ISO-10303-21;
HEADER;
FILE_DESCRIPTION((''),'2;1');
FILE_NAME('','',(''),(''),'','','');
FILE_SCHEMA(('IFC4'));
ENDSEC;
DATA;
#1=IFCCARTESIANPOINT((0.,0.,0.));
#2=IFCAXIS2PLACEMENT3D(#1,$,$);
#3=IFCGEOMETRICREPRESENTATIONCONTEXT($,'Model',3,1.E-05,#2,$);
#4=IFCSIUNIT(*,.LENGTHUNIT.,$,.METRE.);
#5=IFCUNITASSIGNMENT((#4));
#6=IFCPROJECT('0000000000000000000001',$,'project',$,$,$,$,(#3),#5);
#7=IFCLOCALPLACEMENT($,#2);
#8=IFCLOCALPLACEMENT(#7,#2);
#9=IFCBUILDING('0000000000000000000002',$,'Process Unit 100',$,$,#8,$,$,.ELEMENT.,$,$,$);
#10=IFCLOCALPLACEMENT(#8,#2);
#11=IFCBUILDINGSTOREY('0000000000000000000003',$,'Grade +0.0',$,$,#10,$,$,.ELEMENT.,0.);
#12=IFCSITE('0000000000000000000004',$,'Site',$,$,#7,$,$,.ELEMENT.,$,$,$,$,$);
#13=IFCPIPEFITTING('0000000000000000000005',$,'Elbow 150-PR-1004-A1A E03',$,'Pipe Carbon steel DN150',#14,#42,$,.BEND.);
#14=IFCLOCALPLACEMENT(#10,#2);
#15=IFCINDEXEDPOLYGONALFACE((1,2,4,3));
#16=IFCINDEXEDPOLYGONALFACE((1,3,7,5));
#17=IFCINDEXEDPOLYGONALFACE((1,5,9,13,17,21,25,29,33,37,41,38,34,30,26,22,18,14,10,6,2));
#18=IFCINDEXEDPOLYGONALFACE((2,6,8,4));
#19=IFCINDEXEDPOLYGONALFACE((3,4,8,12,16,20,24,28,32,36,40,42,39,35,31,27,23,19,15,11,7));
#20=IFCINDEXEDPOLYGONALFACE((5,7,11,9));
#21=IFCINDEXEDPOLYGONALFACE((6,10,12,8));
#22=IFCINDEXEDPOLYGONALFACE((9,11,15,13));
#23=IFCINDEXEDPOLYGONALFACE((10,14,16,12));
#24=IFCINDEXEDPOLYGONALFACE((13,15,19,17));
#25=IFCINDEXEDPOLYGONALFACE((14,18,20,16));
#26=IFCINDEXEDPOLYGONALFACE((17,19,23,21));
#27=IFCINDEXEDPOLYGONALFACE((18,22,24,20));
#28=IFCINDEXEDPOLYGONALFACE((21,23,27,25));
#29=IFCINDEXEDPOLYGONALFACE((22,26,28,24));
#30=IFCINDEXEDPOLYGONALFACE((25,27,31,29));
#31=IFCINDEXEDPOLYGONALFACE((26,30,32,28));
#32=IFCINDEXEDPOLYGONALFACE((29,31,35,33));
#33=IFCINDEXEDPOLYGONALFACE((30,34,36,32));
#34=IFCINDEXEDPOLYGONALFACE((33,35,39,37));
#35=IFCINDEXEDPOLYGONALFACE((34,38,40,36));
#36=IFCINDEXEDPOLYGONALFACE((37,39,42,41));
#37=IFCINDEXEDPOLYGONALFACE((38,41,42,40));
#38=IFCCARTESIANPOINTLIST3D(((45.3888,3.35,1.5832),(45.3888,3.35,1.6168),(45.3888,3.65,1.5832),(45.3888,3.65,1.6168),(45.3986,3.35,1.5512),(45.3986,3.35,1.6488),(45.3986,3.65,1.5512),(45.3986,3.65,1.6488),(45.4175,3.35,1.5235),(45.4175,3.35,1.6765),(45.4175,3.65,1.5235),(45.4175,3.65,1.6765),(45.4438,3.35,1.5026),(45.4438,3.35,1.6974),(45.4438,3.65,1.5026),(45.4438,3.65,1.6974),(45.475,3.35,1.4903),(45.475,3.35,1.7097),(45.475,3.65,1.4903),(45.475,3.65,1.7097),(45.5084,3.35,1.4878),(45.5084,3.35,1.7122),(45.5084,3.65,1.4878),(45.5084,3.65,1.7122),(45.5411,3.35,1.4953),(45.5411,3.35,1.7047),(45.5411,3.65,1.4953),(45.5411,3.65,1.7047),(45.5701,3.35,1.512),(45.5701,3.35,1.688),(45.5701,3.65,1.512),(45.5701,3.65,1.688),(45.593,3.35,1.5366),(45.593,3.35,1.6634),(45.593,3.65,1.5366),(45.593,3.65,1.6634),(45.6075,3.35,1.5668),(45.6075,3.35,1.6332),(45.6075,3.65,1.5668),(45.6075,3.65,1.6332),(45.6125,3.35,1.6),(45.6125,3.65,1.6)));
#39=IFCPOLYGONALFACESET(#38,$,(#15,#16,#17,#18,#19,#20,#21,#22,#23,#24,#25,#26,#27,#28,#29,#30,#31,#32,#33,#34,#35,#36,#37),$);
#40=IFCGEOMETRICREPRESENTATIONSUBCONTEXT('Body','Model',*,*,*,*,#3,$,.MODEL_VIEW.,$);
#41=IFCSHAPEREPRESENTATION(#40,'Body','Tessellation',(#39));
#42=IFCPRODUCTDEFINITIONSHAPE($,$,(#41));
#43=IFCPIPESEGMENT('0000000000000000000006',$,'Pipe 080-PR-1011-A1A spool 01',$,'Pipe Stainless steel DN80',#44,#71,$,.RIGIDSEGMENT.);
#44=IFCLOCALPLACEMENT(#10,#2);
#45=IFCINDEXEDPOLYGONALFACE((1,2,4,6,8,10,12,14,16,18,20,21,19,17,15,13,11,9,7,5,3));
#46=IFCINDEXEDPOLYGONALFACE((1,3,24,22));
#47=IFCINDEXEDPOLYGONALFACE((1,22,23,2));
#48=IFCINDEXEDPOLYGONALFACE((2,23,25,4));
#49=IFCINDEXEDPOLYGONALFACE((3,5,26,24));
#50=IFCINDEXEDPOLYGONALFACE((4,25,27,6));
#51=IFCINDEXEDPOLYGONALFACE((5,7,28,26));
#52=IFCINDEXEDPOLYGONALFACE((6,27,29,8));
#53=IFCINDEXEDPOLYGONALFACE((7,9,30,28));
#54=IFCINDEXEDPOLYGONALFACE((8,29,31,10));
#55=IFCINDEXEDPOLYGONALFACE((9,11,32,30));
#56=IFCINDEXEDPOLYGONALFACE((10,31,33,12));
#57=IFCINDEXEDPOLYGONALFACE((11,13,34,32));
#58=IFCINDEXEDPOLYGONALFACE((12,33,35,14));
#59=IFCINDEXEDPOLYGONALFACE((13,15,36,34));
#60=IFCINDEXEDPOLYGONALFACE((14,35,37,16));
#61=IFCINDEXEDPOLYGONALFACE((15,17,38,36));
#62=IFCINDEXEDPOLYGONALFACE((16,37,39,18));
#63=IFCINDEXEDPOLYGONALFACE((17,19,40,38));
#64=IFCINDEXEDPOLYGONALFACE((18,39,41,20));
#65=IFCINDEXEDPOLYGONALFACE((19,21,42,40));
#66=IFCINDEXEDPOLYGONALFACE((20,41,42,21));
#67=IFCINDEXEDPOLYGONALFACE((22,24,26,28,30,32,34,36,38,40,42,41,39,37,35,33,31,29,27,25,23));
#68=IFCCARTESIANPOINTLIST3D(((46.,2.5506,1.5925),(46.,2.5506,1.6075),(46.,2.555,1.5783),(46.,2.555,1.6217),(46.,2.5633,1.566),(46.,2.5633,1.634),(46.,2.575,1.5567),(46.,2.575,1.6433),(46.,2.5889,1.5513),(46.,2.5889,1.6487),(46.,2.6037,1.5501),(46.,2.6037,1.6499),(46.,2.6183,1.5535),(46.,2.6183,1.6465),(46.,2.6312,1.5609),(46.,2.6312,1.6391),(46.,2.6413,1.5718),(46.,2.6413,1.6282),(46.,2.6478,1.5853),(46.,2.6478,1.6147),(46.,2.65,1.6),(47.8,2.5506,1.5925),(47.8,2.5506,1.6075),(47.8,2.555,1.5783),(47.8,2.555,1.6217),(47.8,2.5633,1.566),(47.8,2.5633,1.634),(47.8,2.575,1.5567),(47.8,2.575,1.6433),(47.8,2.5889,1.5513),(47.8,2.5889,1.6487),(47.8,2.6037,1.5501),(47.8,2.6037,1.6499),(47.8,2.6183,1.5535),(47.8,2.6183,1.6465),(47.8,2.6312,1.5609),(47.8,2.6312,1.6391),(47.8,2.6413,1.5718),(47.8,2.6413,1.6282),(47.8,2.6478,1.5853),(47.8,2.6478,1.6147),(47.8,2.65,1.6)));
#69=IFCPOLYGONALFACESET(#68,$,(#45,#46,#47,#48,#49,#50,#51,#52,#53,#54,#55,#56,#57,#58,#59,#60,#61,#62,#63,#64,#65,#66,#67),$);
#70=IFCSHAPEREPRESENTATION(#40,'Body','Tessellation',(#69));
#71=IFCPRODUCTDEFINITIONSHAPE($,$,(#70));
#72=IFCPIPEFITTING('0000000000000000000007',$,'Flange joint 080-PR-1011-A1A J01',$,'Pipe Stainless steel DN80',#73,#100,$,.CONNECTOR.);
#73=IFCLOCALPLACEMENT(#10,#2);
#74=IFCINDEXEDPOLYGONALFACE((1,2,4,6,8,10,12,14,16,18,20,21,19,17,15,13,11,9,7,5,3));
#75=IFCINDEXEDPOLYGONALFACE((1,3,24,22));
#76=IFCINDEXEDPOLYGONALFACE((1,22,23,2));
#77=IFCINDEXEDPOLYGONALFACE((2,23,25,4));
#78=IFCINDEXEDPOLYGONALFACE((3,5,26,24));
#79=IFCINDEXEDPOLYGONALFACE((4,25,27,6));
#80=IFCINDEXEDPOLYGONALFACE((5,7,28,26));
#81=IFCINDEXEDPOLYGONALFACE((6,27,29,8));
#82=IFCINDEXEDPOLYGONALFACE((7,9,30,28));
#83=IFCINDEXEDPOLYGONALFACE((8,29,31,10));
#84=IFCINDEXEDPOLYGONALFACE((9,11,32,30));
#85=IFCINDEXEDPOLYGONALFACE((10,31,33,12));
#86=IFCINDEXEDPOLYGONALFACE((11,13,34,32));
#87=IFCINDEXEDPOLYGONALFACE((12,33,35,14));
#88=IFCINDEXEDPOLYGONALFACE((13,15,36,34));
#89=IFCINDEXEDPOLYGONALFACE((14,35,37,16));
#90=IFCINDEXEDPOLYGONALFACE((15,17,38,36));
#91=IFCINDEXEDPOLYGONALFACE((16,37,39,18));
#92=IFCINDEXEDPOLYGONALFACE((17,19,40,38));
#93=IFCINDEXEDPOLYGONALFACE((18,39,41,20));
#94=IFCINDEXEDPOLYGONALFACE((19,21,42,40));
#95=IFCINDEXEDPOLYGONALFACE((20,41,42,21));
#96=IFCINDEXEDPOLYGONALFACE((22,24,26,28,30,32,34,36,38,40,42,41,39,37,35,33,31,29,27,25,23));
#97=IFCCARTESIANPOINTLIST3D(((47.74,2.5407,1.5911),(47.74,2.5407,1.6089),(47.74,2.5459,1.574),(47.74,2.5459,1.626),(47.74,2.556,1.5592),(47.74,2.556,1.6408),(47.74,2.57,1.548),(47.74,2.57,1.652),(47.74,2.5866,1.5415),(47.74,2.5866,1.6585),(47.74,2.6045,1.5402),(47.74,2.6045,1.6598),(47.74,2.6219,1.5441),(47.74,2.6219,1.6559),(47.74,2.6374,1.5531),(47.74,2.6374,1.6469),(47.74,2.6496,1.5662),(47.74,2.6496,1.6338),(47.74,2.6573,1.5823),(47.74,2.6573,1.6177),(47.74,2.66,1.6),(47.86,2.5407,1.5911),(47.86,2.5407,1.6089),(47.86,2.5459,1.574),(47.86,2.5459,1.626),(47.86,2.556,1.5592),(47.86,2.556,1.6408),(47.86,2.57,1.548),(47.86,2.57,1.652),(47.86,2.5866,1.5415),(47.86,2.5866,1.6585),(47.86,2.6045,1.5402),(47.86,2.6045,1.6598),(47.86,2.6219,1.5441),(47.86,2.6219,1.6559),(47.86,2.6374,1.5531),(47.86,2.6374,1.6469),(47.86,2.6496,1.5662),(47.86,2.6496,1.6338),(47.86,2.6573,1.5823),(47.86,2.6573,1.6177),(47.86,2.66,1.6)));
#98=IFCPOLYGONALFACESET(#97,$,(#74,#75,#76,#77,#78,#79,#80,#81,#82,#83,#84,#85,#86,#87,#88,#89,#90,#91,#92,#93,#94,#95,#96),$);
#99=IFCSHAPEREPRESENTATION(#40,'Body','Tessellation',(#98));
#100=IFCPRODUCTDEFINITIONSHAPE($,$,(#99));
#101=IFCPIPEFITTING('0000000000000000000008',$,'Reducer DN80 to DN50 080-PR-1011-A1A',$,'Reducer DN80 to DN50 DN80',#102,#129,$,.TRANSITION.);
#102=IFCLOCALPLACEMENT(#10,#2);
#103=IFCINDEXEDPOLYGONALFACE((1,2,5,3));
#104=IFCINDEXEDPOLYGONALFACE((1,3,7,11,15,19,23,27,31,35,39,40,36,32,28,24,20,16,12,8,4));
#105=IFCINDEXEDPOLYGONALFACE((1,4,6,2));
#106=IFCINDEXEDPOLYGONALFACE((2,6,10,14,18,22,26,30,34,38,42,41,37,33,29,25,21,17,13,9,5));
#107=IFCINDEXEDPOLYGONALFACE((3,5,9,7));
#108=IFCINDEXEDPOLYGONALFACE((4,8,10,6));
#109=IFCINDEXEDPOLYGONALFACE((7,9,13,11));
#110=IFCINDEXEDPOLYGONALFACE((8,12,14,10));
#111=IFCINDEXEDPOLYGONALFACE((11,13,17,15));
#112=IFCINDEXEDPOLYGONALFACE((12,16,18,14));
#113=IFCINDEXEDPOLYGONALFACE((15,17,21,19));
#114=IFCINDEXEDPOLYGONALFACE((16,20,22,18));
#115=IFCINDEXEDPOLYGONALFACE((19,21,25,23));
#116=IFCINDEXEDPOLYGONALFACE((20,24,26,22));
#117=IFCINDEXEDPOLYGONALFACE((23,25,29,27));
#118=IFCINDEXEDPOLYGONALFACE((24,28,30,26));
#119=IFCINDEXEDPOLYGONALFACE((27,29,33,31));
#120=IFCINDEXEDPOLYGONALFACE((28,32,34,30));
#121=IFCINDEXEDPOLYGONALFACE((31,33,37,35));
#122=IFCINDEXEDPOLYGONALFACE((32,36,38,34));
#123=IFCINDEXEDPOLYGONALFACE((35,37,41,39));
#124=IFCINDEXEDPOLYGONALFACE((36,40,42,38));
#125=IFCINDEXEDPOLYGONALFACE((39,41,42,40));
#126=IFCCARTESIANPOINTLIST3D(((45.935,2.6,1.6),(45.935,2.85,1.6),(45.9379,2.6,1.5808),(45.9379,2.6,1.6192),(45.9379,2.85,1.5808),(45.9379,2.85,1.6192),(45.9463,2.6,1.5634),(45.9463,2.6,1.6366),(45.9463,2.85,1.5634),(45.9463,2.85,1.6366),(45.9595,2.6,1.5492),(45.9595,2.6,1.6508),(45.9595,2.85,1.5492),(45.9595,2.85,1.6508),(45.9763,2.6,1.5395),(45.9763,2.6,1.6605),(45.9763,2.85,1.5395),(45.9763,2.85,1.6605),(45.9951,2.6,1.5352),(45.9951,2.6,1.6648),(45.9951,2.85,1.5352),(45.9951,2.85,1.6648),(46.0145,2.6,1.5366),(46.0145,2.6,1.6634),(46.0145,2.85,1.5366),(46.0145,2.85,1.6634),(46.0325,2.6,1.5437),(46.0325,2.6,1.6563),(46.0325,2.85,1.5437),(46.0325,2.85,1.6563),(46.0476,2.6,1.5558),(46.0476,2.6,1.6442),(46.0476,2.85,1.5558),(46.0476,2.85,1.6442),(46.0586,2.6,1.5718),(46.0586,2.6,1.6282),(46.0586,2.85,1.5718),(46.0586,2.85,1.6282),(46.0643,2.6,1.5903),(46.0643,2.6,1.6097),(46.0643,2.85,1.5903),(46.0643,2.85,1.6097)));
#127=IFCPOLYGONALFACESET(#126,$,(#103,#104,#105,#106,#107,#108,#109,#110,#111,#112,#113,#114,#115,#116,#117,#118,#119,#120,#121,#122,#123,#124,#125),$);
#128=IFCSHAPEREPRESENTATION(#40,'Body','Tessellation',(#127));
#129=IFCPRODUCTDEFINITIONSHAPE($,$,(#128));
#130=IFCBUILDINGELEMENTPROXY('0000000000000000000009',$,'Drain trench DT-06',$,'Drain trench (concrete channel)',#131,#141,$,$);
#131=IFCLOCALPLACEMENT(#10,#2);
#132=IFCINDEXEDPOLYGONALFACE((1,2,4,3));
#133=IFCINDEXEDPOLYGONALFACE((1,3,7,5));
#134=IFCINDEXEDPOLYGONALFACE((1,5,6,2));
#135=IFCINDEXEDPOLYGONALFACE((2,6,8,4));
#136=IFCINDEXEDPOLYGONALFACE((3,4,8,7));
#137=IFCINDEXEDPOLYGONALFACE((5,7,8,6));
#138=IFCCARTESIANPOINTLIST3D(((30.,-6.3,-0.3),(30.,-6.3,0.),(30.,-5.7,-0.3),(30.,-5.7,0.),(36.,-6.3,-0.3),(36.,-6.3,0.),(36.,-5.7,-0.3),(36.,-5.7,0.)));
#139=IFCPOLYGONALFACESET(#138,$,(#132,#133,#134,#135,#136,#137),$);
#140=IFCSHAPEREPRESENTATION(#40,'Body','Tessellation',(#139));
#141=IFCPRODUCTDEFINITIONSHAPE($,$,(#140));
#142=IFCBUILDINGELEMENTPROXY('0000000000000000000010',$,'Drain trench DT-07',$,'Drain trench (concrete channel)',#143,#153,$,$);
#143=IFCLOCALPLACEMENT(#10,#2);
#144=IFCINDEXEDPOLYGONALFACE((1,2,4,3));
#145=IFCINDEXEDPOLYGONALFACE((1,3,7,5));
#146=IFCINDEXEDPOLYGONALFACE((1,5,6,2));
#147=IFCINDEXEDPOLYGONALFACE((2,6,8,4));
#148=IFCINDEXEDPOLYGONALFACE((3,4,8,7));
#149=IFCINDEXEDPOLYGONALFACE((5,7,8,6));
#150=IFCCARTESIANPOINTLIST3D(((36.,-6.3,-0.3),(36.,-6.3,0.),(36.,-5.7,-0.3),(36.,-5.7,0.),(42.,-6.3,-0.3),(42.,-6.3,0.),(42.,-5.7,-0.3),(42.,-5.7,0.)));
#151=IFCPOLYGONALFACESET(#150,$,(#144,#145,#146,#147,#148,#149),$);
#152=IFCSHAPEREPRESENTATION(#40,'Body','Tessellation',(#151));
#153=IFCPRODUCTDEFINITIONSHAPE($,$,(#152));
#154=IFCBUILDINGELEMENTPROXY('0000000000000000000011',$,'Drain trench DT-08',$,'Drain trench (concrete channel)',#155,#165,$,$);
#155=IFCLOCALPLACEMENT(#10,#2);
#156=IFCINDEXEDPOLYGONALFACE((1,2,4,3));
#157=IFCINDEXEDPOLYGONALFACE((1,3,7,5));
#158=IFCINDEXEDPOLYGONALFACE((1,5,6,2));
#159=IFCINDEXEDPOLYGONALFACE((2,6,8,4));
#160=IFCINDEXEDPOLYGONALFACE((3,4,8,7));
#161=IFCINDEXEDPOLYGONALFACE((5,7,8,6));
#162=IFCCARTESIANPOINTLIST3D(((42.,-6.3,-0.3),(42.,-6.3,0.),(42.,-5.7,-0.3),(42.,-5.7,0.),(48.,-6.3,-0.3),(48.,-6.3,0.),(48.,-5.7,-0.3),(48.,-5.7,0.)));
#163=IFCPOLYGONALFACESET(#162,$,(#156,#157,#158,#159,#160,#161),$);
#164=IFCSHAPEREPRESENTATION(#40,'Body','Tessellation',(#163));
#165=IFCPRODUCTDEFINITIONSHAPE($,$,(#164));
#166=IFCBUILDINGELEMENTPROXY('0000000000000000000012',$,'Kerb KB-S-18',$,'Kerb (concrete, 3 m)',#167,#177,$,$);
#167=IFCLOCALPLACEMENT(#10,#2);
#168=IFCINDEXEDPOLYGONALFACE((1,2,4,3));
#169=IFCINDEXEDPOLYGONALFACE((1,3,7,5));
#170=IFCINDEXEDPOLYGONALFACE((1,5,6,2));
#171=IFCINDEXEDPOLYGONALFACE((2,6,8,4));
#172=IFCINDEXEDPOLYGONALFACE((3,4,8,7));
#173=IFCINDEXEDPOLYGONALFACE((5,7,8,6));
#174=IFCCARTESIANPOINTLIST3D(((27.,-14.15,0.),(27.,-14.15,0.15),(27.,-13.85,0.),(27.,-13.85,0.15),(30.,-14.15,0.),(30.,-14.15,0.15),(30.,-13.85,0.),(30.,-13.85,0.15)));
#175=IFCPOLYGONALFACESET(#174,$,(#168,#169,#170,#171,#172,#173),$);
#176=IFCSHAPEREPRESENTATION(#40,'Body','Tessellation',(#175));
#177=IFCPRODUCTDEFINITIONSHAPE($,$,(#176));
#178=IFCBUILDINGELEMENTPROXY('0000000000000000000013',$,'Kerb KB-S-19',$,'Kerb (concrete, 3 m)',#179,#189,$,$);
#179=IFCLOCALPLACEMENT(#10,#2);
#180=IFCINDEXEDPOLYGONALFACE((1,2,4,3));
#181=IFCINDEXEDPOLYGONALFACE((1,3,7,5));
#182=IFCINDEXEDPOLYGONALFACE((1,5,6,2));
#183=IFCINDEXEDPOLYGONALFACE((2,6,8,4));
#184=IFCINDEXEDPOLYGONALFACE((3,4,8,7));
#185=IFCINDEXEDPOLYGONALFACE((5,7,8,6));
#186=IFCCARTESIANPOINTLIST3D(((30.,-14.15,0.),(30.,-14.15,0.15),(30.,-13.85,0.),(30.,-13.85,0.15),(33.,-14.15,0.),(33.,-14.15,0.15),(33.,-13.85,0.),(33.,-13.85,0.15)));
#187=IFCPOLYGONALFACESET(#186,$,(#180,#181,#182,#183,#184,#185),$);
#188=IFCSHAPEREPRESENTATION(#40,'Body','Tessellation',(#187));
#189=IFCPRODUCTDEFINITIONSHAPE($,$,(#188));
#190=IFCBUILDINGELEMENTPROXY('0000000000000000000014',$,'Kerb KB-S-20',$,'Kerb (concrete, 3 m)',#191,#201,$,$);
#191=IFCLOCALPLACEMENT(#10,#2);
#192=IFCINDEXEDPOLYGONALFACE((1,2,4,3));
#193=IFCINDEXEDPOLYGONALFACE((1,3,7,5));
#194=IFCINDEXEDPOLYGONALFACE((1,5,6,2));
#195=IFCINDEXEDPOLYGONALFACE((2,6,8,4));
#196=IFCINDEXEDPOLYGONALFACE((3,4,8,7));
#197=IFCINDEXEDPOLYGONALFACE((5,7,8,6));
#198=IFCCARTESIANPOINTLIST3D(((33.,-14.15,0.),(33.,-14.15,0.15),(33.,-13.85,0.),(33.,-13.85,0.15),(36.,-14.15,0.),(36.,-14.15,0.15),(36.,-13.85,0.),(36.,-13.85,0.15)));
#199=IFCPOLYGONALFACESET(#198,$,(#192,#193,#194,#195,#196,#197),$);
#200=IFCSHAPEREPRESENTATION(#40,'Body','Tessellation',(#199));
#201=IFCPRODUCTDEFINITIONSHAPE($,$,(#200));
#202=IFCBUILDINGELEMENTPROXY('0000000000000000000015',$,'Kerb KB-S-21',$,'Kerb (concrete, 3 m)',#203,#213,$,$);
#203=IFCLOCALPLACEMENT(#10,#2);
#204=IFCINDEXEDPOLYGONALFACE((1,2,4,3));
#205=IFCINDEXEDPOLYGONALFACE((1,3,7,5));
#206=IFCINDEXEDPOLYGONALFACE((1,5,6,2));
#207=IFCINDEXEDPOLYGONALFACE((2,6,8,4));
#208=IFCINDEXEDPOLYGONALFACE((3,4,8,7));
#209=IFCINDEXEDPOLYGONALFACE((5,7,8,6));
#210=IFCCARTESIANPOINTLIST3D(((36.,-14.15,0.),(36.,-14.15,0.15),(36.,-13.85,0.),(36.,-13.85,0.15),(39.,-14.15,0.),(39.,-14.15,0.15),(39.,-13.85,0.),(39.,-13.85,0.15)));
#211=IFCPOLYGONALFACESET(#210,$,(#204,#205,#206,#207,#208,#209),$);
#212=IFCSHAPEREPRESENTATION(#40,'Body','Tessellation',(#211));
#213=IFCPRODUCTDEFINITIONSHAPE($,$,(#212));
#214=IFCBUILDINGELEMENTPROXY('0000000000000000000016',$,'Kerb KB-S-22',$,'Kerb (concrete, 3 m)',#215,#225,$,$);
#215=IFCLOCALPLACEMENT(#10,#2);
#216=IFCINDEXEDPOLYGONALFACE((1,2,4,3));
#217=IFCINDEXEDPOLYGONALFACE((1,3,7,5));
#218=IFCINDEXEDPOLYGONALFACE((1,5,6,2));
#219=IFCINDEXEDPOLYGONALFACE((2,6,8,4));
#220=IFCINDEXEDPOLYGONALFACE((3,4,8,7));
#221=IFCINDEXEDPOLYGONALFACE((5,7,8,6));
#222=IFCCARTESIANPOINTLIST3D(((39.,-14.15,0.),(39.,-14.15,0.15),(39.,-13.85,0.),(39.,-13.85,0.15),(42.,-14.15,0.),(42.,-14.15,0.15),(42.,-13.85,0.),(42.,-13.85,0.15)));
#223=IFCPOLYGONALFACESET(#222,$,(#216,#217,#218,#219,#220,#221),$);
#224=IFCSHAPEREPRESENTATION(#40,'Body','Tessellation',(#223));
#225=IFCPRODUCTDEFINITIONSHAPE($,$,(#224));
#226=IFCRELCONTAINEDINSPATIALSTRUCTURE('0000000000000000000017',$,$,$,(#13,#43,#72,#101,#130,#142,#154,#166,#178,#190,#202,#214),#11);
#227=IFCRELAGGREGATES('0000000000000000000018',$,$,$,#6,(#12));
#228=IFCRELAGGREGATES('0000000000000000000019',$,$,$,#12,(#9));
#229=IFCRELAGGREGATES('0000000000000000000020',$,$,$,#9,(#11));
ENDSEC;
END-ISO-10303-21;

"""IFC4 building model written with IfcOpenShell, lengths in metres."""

from ifc_helpers import new_model, si_unit, frame, origin, place, context, subcontext, project, spatial, rectangle, circle, extrude, element, save


model = new_model("IFC4")

# Units and contexts
model_context = context("Model", 3, precision=1e-05, world=origin())
body_context = subcontext(model_context, "Body", "Model", "MODEL_VIEW")
ifc_project = project(units=[si_unit("LENGTHUNIT", "METRE")], contexts=[model_context])

# Site, building, storey
site_placement = place(None, origin())
site = spatial("IfcSite", under=ifc_project, at=site_placement, Name="Site", CompositionType="ELEMENT")
building_placement = place(site_placement, origin())
building = spatial("IfcBuilding", under=site, at=building_placement, Name="Process Unit 100", CompositionType="ELEMENT")
storey_placement = place(building_placement, origin())
storey = spatial("IfcBuildingStorey", under=building, at=storey_placement, Name="Grade +0.0", CompositionType="ELEMENT", Elevation=0.0)

# Pipe fitting
pipe_fitting_1_placement = place(storey_placement, frame((45.5, 3.65, 1.6), z_axis=(0.0, -1.0, 0.0), x_axis=(1.0, 0.0, 0.0)))
element("IfcPipeFitting", 1, at=pipe_fitting_1_placement, inside=storey, Name="Elbow 150-PR-1004-A1A E03", ObjectType="Pipe Carbon steel DN150", PredefinedType="BEND", context=body_context, shape_type="SweptSolid", body=[
    extrude(circle(Radius=0.1125), origin(), (0.0, 0.0, 1.0), 0.3),
])

# Pipe segment
pipe_segment_1_placement = place(storey_placement, frame((46.0, 2.6, 1.6), z_axis=(1.0, 0.0, 0.0), x_axis=(0.0, 1.0, 0.0)))
element("IfcPipeSegment", 2, at=pipe_segment_1_placement, inside=storey, Name="Pipe 080-PR-1011-A1A spool 01", ObjectType="Pipe Stainless steel DN80", PredefinedType="RIGIDSEGMENT", context=body_context, shape_type="SweptSolid", body=[
    extrude(circle(Radius=0.05), origin(), (0.0, 0.0, 1.0), 1.8),
])

# Pipe fittings
pipe_fitting_2_placement = place(storey_placement, frame((47.74, 2.6, 1.6), z_axis=(1.0, 0.0, 0.0), x_axis=(0.0, 1.0, 0.0)))
element("IfcPipeFitting", 3, at=pipe_fitting_2_placement, inside=storey, Name="Flange joint 080-PR-1011-A1A J01", ObjectType="Pipe Stainless steel DN80", PredefinedType="CONNECTOR", context=body_context, shape_type="SweptSolid", body=[
    extrude(circle(Radius=0.06), origin(), (0.0, 0.0, 1.0), 0.12),
])
pipe_fitting_3_placement = place(storey_placement, frame((46.0, 2.6, 1.6), z_axis=(0.0, 1.0, 0.0), x_axis=(-1.0, 0.0, 0.0)))
element("IfcPipeFitting", 4, at=pipe_fitting_3_placement, inside=storey, Name="Reducer DN80 to DN50 080-PR-1011-A1A", ObjectType="Reducer DN80 to DN50 DN80", PredefinedType="TRANSITION", context=body_context, shape_type="SweptSolid", body=[
    extrude(circle(Radius=0.065), origin(), (0.0, 0.0, 1.0), 0.25),
])

# Building element proxies
for number, where, z_axis, x_axis, name in (
    (5, (33.0, -6.0, -0.3), (0.0, 0.0, 1.0), (1.0, 0.0, 0.0), "Drain trench DT-06"),
    (6, (39.0, -6.0, -0.3), (0.0, 0.0, 1.0), (1.0, 0.0, 0.0), "Drain trench DT-07"),
    (7, (45.0, -6.0, -0.3), (0.0, 0.0, 1.0), (1.0, 0.0, 0.0), "Drain trench DT-08"),
):
    element("IfcBuildingElementProxy", number, at=place(storey_placement, frame(where, z_axis=z_axis, x_axis=x_axis)), inside=storey, Name=name, ObjectType="Drain trench (concrete channel)", context=body_context, shape_type="SweptSolid", body=[
        extrude(rectangle(XDim=6.0, YDim=0.6), origin(), (0.0, 0.0, 1.0), 0.3),
    ])
for number, where, z_axis, x_axis, name in (
    (8, (28.5, -14.0, 0.0), (0.0, 0.0, 1.0), (1.0, 0.0, 0.0), "Kerb KB-S-18"),
    (9, (31.5, -14.0, 0.0), (0.0, 0.0, 1.0), (1.0, 0.0, 0.0), "Kerb KB-S-19"),
    (10, (34.5, -14.0, 0.0), (0.0, 0.0, 1.0), (1.0, 0.0, 0.0), "Kerb KB-S-20"),
    (11, (37.5, -14.0, 0.0), (0.0, 0.0, 1.0), (1.0, 0.0, 0.0), "Kerb KB-S-21"),
    (12, (40.5, -14.0, 0.0), (0.0, 0.0, 1.0), (1.0, 0.0, 0.0), "Kerb KB-S-22"),
):
    element("IfcBuildingElementProxy", number, at=place(storey_placement, frame(where, z_axis=z_axis, x_axis=x_axis)), inside=storey, Name=name, ObjectType="Kerb (concrete, 3 m)", context=body_context, shape_type="SweptSolid", body=[
        extrude(rectangle(XDim=3.0, YDim=0.3), origin(), (0.0, 0.0, 1.0), 0.15),
    ])

save(model, "model.ifc")
